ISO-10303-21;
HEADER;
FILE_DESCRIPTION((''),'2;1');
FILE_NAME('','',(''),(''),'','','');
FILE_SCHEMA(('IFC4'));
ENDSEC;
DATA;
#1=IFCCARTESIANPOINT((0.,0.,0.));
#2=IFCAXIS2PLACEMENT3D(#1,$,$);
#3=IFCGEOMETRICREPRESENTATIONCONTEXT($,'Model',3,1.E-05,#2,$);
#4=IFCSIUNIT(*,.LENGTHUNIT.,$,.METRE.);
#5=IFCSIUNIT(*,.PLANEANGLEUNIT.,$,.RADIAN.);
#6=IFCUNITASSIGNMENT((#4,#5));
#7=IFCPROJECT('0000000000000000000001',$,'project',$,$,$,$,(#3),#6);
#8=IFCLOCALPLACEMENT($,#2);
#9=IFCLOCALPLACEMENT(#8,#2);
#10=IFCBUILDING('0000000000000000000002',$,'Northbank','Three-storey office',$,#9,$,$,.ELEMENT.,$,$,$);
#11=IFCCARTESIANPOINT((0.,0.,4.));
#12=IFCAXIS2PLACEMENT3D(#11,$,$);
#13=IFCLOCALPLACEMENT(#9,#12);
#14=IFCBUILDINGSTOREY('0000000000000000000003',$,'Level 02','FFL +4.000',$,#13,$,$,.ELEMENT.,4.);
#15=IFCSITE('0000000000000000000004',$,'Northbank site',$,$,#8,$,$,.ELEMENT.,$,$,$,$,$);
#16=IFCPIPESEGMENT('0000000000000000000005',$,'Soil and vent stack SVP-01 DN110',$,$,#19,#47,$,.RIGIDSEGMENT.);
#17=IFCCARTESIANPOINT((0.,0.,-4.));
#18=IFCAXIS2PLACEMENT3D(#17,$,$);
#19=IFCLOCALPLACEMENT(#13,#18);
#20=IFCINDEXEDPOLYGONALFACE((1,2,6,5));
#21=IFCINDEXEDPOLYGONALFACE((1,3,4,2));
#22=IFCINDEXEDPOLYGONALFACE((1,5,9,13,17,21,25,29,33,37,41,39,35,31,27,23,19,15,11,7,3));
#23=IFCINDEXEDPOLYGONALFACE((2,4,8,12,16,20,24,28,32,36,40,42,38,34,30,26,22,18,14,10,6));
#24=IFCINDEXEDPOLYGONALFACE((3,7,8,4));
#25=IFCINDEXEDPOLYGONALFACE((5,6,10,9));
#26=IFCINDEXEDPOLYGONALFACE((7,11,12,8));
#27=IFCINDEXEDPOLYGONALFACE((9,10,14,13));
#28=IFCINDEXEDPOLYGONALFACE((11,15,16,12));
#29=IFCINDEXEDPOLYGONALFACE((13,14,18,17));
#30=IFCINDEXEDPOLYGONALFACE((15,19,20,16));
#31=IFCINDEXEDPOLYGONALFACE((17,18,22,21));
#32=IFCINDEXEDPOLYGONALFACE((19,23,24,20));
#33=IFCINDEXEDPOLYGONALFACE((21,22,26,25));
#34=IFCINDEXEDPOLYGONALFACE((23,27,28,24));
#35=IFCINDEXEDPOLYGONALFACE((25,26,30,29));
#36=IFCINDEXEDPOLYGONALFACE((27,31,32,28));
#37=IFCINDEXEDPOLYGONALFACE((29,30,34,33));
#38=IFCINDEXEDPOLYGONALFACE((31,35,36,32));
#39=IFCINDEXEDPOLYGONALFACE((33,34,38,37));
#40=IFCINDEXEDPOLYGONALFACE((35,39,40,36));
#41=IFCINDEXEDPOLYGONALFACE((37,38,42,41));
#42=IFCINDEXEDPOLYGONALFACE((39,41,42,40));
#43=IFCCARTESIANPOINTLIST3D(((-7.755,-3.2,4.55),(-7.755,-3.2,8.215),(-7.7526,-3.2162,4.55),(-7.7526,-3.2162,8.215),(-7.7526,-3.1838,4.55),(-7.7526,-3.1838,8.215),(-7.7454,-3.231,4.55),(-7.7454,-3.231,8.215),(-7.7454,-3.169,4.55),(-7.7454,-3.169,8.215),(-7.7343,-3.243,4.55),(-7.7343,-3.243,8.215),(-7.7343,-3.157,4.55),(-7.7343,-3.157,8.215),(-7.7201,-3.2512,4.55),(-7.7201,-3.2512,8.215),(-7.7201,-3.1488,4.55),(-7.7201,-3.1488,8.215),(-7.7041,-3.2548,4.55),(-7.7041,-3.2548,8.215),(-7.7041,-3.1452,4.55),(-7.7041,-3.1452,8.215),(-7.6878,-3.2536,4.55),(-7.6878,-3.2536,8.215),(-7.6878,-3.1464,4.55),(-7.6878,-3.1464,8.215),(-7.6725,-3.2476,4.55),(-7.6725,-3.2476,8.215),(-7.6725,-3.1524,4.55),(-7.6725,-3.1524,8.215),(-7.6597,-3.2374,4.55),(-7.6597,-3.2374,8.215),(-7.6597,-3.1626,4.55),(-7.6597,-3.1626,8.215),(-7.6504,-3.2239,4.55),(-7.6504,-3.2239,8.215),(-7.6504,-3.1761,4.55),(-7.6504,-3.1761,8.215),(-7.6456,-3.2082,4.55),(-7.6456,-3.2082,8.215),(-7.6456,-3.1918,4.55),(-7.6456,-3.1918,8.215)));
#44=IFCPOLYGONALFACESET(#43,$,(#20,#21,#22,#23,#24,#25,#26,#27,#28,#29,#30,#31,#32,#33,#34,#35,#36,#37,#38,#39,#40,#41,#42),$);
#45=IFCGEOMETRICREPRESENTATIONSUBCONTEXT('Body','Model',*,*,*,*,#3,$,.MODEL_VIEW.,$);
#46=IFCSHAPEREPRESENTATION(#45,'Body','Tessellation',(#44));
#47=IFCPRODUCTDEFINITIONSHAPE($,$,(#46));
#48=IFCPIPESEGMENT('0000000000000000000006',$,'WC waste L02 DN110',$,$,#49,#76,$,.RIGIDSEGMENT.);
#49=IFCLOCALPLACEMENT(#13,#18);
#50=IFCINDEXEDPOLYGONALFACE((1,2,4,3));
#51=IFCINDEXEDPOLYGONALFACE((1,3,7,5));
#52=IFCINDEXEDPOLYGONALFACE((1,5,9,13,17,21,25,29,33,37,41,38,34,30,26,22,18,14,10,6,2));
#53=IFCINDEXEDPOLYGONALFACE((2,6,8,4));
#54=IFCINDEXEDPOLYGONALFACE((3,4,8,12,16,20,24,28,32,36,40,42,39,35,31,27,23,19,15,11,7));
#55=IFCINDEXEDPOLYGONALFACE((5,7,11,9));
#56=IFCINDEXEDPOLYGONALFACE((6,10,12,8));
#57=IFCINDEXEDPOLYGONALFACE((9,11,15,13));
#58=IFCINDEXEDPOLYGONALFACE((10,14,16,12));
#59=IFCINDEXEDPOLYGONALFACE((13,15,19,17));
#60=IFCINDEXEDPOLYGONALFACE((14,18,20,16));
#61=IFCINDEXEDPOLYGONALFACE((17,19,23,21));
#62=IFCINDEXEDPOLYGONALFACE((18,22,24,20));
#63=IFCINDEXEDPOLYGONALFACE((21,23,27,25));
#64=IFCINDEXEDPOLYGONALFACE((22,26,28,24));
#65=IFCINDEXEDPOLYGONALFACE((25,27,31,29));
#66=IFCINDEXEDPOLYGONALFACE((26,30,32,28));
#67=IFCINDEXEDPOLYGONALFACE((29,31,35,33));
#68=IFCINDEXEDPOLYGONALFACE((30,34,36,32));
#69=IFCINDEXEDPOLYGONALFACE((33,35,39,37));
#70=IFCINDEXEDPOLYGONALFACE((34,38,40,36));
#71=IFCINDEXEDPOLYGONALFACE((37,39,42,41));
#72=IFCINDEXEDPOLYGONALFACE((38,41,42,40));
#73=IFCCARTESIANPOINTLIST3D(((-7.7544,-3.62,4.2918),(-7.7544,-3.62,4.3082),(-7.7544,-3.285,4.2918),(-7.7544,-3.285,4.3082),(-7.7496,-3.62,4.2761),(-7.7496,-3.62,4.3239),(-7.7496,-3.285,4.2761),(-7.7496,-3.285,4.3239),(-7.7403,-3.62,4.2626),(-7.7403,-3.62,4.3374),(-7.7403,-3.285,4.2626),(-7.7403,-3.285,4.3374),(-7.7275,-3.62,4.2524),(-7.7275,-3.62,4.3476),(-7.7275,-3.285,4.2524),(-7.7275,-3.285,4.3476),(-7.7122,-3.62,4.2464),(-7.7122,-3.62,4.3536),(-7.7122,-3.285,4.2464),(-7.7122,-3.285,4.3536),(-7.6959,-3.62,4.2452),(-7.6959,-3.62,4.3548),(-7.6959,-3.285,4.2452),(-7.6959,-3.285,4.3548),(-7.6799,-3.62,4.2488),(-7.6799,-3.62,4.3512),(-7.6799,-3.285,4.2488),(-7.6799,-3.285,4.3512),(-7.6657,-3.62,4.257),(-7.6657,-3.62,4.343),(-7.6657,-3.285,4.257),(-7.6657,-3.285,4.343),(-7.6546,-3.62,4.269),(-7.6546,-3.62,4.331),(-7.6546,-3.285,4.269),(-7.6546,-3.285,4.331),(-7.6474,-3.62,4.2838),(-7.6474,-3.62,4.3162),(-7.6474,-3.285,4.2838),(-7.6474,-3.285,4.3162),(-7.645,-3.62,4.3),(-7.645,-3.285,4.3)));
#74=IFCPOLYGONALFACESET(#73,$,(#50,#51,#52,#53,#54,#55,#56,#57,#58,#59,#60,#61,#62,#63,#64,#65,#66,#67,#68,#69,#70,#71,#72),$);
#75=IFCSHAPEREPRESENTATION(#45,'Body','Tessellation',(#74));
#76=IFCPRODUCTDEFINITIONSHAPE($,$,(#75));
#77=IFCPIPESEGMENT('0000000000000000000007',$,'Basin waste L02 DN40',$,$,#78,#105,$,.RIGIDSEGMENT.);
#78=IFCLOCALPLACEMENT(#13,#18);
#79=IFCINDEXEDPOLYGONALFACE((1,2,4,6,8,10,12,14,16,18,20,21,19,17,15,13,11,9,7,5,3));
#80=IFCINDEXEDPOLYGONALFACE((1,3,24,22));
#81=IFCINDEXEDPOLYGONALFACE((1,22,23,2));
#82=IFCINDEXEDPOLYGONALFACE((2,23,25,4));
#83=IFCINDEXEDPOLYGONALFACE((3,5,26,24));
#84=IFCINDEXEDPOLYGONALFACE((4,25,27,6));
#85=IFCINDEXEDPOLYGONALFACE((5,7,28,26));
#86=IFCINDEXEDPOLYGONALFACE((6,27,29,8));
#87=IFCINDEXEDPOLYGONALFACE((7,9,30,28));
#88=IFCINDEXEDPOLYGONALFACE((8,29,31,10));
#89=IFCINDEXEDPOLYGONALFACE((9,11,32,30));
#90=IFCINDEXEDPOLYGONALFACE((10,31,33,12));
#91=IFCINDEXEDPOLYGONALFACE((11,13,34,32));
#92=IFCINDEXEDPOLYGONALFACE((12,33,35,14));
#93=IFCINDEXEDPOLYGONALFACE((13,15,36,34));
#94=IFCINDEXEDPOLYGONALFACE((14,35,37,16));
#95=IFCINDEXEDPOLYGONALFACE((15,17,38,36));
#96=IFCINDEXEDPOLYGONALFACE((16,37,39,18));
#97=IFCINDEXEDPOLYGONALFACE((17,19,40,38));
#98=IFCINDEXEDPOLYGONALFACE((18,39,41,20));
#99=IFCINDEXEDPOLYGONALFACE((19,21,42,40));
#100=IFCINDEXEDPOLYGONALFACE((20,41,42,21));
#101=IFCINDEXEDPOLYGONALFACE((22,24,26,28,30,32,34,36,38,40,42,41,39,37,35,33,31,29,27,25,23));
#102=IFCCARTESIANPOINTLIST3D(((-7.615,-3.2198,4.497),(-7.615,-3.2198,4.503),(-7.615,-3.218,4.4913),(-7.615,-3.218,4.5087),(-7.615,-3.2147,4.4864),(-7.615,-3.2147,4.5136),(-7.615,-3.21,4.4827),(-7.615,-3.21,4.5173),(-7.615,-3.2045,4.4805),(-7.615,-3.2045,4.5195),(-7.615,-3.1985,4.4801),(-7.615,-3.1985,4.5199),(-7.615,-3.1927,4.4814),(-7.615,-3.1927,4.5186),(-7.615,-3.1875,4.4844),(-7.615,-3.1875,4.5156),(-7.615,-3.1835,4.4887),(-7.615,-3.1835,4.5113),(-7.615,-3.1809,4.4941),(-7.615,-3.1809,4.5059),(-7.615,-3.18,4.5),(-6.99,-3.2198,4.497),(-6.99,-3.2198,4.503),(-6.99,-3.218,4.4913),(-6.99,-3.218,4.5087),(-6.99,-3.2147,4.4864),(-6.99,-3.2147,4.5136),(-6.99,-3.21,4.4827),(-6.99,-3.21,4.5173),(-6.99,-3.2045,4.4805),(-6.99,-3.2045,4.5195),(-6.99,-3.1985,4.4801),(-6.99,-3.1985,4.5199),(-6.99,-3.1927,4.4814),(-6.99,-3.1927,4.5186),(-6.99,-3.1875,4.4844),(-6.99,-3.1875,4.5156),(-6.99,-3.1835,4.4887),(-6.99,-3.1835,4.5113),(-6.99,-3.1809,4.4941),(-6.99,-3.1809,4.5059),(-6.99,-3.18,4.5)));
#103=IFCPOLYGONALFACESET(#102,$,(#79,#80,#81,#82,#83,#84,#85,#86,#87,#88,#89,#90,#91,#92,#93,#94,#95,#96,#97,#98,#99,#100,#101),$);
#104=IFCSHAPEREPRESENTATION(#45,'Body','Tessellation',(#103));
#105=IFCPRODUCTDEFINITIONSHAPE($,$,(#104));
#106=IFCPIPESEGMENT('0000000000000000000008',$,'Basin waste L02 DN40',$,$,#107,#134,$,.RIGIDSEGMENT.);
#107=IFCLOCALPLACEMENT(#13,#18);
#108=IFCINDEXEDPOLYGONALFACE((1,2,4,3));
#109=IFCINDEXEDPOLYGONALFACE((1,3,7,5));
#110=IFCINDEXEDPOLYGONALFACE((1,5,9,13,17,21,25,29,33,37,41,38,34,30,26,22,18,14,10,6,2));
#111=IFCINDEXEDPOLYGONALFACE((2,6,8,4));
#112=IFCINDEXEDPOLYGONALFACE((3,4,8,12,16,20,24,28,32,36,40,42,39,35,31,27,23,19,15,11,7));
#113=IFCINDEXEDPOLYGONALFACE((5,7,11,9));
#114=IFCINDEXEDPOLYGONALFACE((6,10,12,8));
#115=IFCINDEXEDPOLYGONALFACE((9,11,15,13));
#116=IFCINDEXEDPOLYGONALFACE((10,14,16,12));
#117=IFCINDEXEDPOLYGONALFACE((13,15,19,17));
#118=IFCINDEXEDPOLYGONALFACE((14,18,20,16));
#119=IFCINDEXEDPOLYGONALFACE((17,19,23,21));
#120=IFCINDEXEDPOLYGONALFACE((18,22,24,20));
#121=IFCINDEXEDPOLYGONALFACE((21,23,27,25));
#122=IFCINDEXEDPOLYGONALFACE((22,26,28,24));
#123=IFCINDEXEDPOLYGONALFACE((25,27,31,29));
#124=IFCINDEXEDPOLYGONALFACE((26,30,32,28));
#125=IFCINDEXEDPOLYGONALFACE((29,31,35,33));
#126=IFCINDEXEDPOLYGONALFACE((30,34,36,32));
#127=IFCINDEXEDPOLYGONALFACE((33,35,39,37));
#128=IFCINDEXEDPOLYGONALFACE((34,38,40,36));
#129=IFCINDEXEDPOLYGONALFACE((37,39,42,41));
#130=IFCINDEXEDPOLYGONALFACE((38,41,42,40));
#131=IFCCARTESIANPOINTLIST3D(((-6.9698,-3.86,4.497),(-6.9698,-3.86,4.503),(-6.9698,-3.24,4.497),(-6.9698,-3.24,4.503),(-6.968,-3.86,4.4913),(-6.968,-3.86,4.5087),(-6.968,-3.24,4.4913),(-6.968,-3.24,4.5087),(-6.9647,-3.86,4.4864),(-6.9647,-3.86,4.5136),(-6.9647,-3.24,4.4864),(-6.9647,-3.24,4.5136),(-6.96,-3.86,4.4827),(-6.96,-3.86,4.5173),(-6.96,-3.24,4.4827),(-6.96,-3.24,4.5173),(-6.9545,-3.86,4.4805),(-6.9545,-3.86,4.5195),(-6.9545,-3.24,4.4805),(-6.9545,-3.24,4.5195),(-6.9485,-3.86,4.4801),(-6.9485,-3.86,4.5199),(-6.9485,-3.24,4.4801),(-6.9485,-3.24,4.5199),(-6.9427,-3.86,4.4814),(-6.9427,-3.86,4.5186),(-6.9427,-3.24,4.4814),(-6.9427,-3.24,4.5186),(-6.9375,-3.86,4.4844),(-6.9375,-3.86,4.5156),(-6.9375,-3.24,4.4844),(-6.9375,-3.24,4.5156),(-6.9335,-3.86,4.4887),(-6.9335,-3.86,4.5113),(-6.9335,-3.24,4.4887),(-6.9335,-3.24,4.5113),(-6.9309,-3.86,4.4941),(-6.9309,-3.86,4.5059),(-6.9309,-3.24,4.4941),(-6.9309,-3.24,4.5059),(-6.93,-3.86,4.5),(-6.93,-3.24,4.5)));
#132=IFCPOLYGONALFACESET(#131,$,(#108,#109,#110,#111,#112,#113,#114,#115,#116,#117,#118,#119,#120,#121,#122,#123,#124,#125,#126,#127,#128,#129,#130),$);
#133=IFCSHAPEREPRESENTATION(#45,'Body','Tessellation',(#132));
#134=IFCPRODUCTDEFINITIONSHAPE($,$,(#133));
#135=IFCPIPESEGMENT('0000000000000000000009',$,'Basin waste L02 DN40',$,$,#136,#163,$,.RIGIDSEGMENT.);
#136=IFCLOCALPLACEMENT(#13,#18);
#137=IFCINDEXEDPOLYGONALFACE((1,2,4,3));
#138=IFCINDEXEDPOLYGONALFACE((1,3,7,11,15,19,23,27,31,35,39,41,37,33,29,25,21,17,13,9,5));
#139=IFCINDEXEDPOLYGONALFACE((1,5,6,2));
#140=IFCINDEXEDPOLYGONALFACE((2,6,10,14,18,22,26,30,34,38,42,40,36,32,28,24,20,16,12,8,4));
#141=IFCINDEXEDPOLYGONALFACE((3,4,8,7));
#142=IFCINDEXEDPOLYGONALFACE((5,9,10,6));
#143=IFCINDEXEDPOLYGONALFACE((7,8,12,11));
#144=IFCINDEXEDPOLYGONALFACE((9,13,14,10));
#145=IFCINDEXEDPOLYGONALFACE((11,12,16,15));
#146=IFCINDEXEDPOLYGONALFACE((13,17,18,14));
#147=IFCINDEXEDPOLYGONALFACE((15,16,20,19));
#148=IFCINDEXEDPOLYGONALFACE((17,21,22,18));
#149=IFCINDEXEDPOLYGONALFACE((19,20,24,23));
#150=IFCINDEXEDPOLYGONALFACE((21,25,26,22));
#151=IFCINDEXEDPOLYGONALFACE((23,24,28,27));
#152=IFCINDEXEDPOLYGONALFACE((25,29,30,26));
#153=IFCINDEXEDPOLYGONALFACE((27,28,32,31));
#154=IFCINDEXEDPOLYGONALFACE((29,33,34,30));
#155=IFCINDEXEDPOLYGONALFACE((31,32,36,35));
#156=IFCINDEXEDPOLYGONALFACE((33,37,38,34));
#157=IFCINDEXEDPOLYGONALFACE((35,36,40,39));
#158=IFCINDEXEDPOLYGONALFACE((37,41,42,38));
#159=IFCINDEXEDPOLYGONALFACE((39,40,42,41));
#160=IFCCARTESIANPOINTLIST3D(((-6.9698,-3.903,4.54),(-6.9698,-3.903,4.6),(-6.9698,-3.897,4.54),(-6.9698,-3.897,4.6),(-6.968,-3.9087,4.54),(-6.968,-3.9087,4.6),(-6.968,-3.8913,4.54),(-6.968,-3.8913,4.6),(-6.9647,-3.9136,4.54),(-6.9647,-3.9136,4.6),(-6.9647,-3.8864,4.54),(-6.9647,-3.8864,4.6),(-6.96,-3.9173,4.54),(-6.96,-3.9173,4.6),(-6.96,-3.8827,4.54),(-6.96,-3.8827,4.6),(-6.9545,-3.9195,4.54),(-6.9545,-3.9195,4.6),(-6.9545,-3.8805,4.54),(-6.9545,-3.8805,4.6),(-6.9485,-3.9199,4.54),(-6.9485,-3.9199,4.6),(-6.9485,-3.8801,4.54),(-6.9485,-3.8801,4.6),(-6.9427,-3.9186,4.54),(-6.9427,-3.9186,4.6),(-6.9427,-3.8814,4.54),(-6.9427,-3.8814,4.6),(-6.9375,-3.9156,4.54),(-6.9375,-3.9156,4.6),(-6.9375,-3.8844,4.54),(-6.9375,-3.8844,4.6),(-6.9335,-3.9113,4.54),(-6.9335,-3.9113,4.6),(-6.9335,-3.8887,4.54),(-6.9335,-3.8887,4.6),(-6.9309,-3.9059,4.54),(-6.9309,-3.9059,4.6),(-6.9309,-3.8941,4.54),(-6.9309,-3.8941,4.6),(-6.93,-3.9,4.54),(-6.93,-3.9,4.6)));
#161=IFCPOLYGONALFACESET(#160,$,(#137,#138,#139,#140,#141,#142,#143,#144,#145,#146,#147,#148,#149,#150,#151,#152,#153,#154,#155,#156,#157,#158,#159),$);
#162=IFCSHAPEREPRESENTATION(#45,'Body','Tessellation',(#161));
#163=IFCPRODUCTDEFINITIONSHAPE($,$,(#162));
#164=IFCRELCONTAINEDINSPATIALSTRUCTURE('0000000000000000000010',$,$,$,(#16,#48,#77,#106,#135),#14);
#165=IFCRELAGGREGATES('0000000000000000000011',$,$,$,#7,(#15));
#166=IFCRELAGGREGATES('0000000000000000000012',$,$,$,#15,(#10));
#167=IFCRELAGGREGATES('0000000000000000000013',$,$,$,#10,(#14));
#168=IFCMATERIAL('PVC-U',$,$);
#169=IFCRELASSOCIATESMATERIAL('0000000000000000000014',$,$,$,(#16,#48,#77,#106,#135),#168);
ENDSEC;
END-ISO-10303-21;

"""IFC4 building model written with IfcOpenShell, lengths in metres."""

from ifc_helpers import new_model, si_unit, frame, origin, place, context, subcontext, project, spatial, circle, extrude, material, element, save


model = new_model("IFC4")

# Units and contexts
model_context = context("Model", 3, precision=1e-05, world=origin())
body_context = subcontext(model_context, "Body", "Model", "MODEL_VIEW")
ifc_project = project(units=[si_unit("LENGTHUNIT", "METRE"), si_unit("PLANEANGLEUNIT", "RADIAN")], contexts=[model_context])

# Site, building, storey
site_placement = place(None, origin())
site = spatial("IfcSite", under=ifc_project, at=site_placement, Name="Northbank site", CompositionType="ELEMENT")
building_placement = place(site_placement, origin())
building = spatial("IfcBuilding", under=site, at=building_placement, Name="Northbank", Description="Three-storey office", CompositionType="ELEMENT")
storey_placement = place(building_placement, frame((0.0, 0.0, 4.0)))
storey = spatial("IfcBuildingStorey", under=building, at=storey_placement, Name="Level 02", Description="FFL +4.000", CompositionType="ELEMENT", Elevation=4.0)

# Shared definitions
ifc_material_1 = material(Name="PVC-U")

# Pipe segments
pipe_segment_1_placement = place(storey_placement, frame((0.0, 0.0, -4.0)))
element("IfcPipeSegment", 1, at=pipe_segment_1_placement, inside=storey, material=ifc_material_1, Name="Soil and vent stack SVP-01 DN110", PredefinedType="RIGIDSEGMENT", context=body_context, shape_type="SweptSolid", body=[
    extrude(circle(Radius=0.055), frame((-7.7, -3.2, 4.55), z_axis=(0.0, 0.0, 1.0), x_axis=(-1.0, 0.0, 0.0)), (0.0, 0.0, 1.0), 3.665),
])
pipe_segment_2_placement = place(storey_placement, frame((0.0, 0.0, -4.0)))
element("IfcPipeSegment", 2, at=pipe_segment_2_placement, inside=storey, material=ifc_material_1, Name="WC waste L02 DN110", PredefinedType="RIGIDSEGMENT", context=body_context, shape_type="SweptSolid", body=[
    extrude(circle(Radius=0.055), frame((-7.7, -3.285, 4.3), z_axis=(0.0, -1.0, 0.0), x_axis=(1.0, 0.0, 0.0)), (0.0, 0.0, 1.0), 0.335),
])
pipe_segment_3_placement = place(storey_placement, frame((0.0, 0.0, -4.0)))
element("IfcPipeSegment", 3, at=pipe_segment_3_placement, inside=storey, material=ifc_material_1, Name="Basin waste L02 DN40", PredefinedType="RIGIDSEGMENT", context=body_context, shape_type="SweptSolid", body=[
    extrude(circle(Radius=0.02), frame((-7.615, -3.2, 4.5), z_axis=(1.0, 0.0, 0.0), x_axis=(0.0, 1.0, 0.0)), (0.0, 0.0, 1.0), 0.625),
])
pipe_segment_4_placement = place(storey_placement, frame((0.0, 0.0, -4.0)))
element("IfcPipeSegment", 4, at=pipe_segment_4_placement, inside=storey, material=ifc_material_1, Name="Basin waste L02 DN40", PredefinedType="RIGIDSEGMENT", context=body_context, shape_type="SweptSolid", body=[
    extrude(circle(Radius=0.02), frame((-6.95, -3.24, 4.5), z_axis=(0.0, -1.0, 0.0), x_axis=(1.0, 0.0, 0.0)), (0.0, 0.0, 1.0), 0.62),
])
pipe_segment_5_placement = place(storey_placement, frame((0.0, 0.0, -4.0)))
element("IfcPipeSegment", 5, at=pipe_segment_5_placement, inside=storey, material=ifc_material_1, Name="Basin waste L02 DN40", PredefinedType="RIGIDSEGMENT", context=body_context, shape_type="SweptSolid", body=[
    extrude(circle(Radius=0.02), frame((-6.95, -3.9, 4.54), z_axis=(0.0, 0.0, 1.0), x_axis=(1.0, 0.0, 0.0)), (0.0, 0.0, 1.0), 0.06),
])

save(model, "model.ifc")
